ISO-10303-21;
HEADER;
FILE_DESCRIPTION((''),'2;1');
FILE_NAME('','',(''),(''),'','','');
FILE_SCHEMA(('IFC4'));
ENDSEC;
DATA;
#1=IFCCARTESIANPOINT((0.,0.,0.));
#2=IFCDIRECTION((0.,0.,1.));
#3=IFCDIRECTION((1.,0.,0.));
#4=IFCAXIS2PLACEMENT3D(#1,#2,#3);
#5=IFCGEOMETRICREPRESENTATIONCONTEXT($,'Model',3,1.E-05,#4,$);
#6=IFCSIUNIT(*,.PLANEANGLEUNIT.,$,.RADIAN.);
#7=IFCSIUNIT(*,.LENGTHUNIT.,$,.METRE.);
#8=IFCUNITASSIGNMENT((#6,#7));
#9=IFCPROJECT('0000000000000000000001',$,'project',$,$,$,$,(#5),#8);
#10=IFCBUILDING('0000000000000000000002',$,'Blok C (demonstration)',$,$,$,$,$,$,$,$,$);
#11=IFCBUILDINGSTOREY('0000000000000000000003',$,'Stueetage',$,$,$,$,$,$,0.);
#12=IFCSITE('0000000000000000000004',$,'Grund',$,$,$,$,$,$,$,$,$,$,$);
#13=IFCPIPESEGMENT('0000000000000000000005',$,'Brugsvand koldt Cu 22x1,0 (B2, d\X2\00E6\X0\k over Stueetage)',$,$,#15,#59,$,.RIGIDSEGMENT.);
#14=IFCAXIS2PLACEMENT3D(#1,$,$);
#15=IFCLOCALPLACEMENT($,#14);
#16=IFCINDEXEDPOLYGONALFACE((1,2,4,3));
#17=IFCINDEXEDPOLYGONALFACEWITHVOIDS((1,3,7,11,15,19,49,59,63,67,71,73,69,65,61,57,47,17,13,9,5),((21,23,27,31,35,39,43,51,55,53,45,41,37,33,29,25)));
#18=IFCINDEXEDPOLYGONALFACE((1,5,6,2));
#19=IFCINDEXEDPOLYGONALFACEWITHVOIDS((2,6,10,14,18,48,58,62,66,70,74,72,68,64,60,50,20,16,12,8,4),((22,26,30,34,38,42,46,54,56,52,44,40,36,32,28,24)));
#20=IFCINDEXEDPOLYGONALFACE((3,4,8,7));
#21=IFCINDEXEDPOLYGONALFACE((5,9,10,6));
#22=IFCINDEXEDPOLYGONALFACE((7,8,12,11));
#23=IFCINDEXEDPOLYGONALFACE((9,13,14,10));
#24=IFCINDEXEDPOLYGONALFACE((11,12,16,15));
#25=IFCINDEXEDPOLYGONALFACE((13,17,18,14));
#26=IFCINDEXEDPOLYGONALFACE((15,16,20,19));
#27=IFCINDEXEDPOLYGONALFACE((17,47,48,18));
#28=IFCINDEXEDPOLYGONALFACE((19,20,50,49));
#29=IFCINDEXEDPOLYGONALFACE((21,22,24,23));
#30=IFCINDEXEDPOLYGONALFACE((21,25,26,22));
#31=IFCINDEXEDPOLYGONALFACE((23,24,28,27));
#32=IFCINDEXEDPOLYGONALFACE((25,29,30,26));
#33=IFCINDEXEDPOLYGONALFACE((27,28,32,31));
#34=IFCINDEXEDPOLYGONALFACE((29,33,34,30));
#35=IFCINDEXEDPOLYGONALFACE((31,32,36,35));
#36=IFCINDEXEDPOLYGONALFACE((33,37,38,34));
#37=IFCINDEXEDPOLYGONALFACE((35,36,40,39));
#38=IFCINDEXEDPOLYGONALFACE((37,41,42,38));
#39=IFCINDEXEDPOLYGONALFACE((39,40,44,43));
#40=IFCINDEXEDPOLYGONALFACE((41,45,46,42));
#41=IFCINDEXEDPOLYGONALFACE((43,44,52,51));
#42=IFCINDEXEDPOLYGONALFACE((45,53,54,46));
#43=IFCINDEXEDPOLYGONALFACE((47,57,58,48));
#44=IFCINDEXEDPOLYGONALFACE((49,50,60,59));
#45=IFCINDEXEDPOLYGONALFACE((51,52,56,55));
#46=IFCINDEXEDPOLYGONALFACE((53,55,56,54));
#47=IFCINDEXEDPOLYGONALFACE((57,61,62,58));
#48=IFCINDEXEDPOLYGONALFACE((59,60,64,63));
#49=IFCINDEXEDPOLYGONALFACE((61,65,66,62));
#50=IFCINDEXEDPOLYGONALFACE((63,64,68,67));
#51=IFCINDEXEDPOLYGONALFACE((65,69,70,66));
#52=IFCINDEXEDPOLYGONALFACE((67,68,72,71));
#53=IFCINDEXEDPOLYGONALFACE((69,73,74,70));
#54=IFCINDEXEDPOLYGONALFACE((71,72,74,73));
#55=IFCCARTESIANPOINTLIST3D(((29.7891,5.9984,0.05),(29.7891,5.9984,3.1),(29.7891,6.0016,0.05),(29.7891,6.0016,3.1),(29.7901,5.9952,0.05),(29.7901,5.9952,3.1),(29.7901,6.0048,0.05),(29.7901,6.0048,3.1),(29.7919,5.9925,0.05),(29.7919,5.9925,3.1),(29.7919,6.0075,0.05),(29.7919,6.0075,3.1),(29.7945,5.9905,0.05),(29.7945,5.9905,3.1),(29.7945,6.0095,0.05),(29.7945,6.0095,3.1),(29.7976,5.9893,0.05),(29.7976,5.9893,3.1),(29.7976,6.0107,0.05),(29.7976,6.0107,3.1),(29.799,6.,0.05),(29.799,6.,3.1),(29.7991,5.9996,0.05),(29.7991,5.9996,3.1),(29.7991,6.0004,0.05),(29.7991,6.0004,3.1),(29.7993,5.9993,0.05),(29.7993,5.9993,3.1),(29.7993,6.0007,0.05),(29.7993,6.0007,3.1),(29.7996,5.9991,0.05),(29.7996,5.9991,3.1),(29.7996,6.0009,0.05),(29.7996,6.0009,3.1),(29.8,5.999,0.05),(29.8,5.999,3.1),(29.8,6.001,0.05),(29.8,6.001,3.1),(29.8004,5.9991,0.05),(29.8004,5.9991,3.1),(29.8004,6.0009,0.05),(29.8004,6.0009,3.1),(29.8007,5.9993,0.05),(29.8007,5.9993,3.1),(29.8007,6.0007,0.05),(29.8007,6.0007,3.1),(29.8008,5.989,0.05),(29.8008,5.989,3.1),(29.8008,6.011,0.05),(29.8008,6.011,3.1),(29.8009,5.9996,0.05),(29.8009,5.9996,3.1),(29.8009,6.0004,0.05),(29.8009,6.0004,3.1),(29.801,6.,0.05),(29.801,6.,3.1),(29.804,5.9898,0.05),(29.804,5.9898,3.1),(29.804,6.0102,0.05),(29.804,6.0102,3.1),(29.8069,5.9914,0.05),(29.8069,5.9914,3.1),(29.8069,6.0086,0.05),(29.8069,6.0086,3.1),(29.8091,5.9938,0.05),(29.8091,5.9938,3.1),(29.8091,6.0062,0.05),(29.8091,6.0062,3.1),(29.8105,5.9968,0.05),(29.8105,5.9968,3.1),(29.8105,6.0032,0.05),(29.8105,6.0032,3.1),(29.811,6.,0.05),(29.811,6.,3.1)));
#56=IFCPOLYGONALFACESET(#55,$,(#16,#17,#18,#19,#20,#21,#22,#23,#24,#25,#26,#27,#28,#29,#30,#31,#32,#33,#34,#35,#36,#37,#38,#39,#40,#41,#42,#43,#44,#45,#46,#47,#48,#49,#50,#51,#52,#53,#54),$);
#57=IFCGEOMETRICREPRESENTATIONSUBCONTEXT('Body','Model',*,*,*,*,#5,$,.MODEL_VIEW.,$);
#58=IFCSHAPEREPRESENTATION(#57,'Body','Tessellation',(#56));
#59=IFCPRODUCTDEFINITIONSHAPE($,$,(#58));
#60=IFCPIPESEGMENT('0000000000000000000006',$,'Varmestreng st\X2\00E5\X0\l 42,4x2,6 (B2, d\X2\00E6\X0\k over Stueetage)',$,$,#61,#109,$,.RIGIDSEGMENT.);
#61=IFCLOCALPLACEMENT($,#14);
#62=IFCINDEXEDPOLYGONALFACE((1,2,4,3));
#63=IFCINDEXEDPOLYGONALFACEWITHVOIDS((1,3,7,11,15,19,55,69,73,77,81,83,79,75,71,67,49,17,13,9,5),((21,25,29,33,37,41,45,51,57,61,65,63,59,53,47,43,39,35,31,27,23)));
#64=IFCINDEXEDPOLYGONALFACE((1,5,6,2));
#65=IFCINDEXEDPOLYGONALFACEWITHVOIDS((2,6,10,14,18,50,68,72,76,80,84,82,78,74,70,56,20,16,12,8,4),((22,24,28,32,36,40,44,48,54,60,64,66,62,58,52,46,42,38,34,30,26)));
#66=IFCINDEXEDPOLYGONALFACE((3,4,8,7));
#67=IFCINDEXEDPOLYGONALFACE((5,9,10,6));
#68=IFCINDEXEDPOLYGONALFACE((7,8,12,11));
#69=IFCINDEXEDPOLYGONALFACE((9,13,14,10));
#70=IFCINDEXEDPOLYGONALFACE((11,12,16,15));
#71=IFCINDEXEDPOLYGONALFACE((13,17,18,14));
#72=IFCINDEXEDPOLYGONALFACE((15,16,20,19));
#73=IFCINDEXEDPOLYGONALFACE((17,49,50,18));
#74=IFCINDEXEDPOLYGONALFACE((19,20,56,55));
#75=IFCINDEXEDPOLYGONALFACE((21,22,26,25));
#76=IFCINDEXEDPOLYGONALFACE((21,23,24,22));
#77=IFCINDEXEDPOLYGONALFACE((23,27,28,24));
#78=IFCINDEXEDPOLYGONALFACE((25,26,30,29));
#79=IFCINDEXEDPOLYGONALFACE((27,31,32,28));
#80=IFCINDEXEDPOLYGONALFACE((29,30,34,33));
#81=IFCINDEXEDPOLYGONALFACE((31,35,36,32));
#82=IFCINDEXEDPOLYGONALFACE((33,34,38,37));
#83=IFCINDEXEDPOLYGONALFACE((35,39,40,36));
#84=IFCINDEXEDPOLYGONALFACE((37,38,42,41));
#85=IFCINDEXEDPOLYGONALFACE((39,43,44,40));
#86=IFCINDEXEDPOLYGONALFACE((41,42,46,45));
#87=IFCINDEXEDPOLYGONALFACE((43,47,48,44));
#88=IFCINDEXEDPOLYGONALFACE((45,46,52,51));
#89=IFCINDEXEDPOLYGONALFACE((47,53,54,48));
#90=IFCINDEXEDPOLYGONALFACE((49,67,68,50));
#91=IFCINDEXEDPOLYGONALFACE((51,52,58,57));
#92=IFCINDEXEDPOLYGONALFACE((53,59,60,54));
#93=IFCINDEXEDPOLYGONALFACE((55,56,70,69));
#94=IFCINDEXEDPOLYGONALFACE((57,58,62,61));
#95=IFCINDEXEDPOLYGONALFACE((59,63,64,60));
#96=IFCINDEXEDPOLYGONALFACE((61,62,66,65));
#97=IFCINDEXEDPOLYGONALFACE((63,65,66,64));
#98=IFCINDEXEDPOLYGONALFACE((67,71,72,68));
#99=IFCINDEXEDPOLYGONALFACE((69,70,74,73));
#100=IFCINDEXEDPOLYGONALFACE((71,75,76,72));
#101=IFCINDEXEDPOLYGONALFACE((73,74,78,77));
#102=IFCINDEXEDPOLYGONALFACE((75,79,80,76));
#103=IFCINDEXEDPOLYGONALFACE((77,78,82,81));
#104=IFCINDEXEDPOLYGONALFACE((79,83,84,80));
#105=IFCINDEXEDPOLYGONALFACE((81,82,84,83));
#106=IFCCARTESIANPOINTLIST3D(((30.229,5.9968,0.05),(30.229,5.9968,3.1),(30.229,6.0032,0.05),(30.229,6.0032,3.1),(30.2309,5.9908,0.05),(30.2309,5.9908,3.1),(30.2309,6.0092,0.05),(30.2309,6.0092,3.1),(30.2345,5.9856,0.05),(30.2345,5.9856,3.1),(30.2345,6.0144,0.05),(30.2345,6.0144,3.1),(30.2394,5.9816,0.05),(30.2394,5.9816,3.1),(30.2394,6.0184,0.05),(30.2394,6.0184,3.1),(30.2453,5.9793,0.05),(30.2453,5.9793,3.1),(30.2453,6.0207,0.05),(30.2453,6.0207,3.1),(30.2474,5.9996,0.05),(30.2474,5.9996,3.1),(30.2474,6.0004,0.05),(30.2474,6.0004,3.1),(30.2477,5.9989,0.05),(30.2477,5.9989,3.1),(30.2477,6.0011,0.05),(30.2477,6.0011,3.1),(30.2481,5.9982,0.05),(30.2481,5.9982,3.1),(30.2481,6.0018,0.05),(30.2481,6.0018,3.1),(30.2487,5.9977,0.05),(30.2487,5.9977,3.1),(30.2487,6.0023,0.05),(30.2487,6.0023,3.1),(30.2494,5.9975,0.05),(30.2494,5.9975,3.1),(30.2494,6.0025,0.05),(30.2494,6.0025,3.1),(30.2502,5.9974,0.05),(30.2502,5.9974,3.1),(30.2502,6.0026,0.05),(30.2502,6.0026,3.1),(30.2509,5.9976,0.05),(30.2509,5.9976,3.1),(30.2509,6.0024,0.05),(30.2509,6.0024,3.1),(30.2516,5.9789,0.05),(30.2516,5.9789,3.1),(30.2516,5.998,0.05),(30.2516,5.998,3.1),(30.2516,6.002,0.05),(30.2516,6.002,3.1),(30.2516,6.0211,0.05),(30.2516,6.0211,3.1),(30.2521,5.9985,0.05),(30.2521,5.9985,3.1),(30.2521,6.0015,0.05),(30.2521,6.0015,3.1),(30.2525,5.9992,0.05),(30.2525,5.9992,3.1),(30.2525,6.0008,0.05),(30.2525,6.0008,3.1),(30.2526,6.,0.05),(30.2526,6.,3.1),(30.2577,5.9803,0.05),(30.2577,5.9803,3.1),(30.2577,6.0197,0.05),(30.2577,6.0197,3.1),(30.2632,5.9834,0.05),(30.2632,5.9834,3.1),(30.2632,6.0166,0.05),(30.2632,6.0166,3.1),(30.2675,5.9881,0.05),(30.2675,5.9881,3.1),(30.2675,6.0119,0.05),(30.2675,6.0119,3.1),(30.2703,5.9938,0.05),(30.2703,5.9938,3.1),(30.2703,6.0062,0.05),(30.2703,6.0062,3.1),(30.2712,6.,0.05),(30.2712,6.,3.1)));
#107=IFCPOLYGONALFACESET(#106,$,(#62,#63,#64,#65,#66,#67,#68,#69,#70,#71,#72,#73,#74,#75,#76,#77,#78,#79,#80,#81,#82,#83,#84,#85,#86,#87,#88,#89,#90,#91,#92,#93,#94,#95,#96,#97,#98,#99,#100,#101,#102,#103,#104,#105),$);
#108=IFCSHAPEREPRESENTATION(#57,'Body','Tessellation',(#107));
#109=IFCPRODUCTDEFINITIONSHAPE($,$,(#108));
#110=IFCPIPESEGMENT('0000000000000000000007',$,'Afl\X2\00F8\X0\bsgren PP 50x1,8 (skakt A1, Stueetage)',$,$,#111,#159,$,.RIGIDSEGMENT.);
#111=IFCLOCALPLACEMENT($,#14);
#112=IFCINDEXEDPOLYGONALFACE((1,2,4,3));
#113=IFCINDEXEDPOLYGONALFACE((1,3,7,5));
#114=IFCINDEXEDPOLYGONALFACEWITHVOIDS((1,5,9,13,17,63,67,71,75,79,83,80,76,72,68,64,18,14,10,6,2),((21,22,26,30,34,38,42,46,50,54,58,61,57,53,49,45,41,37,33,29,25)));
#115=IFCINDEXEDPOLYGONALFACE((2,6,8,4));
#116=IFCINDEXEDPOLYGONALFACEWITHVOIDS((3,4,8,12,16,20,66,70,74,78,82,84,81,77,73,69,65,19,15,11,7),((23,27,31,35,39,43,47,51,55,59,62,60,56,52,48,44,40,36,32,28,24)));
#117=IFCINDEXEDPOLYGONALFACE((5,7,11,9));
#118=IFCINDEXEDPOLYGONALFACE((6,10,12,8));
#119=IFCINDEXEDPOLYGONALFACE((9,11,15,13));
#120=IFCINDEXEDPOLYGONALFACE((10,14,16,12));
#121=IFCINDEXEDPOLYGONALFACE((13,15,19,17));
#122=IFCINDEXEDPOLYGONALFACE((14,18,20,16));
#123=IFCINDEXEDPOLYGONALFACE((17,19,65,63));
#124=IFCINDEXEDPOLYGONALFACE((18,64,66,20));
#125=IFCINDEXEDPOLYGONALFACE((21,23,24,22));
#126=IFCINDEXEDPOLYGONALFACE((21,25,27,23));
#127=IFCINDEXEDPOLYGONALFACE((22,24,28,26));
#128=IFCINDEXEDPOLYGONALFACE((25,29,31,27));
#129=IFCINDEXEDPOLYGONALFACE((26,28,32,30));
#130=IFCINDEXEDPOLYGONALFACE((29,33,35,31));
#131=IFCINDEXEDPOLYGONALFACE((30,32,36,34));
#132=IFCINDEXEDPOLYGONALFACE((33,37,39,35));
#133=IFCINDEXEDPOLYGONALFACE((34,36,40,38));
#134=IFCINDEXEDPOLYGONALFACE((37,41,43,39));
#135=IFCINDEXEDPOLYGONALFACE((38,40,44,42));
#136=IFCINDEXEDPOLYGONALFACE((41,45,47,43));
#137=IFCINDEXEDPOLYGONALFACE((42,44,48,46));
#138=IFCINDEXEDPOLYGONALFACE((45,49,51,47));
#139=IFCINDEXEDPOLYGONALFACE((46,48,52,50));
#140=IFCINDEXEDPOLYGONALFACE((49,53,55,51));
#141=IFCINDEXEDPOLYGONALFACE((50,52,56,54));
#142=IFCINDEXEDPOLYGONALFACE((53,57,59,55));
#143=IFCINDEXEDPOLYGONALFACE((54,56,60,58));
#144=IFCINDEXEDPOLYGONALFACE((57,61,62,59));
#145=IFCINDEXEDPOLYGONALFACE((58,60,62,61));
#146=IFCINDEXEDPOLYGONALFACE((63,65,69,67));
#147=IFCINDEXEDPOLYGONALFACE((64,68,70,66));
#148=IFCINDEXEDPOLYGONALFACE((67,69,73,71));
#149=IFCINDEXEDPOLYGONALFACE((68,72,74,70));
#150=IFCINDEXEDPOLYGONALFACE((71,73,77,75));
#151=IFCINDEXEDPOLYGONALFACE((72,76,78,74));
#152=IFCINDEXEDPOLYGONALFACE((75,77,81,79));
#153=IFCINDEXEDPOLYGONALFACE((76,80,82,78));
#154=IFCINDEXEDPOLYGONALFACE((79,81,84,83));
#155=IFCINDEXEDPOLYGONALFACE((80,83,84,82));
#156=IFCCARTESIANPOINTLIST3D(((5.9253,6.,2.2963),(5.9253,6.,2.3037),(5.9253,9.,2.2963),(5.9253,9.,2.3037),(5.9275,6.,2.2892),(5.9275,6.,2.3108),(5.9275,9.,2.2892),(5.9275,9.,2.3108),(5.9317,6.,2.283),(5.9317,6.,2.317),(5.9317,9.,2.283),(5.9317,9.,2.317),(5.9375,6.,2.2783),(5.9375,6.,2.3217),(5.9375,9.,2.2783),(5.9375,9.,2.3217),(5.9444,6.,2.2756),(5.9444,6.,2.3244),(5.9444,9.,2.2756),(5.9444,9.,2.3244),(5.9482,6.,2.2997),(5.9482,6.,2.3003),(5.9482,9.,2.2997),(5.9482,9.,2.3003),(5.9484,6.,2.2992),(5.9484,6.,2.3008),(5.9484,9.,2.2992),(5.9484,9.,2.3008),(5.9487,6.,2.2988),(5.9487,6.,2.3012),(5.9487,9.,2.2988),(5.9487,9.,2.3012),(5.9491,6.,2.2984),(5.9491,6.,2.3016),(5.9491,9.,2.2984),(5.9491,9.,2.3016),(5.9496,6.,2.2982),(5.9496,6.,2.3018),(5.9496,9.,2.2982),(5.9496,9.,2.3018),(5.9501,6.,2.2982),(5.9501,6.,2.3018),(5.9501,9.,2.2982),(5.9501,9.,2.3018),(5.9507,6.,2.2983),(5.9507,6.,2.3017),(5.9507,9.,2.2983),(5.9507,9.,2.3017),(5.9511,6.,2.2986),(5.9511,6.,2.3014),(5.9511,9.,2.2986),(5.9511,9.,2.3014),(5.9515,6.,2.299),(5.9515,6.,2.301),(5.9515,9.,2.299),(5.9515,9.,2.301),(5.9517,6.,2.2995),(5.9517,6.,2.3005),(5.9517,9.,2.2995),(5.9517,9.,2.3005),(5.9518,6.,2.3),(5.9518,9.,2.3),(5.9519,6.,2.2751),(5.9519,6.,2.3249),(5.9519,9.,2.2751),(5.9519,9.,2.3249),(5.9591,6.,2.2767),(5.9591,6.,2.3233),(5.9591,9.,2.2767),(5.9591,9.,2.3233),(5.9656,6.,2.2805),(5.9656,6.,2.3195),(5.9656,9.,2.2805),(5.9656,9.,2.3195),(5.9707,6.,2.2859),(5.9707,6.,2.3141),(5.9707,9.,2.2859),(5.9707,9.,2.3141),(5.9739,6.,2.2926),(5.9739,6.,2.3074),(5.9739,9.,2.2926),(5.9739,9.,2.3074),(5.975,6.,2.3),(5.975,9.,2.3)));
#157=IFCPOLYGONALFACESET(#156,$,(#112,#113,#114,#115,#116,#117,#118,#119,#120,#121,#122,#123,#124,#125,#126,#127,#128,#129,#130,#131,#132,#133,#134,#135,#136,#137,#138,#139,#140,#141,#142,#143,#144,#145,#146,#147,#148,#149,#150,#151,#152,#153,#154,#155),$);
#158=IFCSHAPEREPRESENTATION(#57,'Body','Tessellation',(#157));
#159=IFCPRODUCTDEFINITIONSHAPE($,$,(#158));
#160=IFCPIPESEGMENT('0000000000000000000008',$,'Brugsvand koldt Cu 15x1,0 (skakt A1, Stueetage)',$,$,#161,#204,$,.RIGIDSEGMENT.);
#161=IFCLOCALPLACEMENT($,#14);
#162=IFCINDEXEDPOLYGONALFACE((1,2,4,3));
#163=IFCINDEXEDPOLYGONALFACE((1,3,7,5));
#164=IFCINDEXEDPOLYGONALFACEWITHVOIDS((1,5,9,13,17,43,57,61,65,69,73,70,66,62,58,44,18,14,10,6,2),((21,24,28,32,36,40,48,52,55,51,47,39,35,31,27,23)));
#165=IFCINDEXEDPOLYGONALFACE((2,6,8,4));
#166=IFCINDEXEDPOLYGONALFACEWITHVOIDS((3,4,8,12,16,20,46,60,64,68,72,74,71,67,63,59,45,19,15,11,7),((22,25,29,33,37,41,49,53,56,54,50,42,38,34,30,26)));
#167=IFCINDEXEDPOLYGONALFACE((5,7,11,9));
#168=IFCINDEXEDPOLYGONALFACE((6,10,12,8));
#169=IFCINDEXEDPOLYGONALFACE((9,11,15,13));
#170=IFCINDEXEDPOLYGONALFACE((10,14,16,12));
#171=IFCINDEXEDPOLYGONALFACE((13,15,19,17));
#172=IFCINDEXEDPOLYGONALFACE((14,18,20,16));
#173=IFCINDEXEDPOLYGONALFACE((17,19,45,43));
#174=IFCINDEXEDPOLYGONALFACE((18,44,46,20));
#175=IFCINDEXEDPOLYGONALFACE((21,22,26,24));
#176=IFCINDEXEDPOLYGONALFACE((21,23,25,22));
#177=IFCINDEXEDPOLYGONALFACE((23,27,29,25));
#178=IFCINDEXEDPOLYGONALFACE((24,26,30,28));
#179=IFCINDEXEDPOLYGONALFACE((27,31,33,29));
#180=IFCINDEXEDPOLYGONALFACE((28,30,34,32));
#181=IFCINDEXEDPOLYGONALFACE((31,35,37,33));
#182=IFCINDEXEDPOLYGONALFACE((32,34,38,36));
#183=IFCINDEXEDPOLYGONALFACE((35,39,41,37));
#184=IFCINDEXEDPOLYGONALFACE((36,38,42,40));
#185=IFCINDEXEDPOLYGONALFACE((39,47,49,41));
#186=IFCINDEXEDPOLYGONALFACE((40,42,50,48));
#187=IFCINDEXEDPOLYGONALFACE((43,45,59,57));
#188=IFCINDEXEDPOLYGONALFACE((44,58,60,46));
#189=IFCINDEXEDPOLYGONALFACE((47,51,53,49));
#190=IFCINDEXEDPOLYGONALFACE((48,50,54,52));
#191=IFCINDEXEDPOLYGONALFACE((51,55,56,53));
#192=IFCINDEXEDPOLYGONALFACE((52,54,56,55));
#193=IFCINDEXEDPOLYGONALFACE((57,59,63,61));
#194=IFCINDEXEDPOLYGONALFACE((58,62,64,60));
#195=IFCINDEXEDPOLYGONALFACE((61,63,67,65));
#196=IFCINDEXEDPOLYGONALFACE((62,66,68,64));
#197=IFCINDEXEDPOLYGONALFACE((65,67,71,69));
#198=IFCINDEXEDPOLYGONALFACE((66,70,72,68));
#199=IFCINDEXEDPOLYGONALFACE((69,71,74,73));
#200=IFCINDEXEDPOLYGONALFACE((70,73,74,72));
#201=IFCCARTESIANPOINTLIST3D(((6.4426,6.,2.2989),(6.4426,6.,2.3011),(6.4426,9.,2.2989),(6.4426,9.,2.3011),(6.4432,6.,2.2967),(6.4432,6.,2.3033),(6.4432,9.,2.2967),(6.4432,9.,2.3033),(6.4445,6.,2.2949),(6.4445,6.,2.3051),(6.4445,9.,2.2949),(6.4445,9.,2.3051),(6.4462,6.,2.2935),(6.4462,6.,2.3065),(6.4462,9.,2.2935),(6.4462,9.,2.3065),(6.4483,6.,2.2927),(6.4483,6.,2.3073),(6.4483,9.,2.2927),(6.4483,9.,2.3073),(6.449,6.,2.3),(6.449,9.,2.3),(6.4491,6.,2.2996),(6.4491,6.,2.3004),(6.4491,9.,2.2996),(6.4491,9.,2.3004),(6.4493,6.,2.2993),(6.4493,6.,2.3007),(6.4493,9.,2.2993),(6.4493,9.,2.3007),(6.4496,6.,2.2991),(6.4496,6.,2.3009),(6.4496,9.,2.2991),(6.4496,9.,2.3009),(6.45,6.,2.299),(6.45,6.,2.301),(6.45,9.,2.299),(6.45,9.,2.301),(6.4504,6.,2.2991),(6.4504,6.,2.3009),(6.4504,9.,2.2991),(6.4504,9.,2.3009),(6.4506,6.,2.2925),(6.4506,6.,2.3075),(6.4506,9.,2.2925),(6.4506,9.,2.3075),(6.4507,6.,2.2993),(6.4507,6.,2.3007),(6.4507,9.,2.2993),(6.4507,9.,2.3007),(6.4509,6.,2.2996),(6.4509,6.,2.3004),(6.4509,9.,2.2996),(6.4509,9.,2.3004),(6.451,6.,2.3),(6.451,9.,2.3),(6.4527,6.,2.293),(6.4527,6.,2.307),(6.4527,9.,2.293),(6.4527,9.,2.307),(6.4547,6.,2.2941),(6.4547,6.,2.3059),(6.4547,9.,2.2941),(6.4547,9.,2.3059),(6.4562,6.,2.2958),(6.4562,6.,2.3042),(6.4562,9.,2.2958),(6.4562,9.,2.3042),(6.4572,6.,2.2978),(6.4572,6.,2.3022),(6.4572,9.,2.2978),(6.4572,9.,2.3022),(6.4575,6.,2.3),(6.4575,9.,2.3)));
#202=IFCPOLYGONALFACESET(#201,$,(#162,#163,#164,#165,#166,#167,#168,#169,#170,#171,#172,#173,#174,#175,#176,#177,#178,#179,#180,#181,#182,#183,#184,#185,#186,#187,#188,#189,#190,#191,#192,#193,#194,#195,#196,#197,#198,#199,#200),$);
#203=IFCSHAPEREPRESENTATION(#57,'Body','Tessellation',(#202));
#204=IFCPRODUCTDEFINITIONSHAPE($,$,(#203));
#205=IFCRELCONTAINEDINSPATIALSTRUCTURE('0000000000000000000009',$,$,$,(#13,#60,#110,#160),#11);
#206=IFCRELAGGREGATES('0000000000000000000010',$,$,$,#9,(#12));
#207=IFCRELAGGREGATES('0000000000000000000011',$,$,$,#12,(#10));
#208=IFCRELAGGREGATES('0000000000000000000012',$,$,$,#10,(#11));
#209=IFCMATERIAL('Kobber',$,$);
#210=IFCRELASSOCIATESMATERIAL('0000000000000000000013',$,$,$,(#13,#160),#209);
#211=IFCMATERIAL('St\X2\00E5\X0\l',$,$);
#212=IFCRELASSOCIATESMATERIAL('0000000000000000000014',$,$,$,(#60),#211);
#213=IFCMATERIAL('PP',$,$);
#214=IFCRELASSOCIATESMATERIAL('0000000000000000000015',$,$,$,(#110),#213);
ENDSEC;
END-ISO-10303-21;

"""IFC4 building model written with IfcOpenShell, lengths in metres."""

from ifc_helpers import new_model, si_unit, frame, origin_with_axes, place, context, subcontext, project, spatial, hollow_circle, extrude, material, element, save


model = new_model("IFC4")

# Units and contexts
model_context = context("Model", 3, precision=1e-05, world=origin_with_axes())
body_context = subcontext(model_context, "Body", "Model", "MODEL_VIEW")
ifc_project = project(units=[si_unit("PLANEANGLEUNIT", "RADIAN"), si_unit("LENGTHUNIT", "METRE")], contexts=[model_context])

# Site, building, storey
site = spatial("IfcSite", under=ifc_project, Name="Grund")
building = spatial("IfcBuilding", under=site, Name="Blok C (demonstration)")
storey = spatial("IfcBuildingStorey", under=building, Name="Stueetage", Elevation=0.0)

# Pipe segments
ifc_material_1 = material(Name="Kobber")
ifc_material_2 = material(Name="PP")
pipe_segment_1_placement = place(None, origin_with_axes())
element("IfcPipeSegment", 1, at=pipe_segment_1_placement, inside=storey, material=ifc_material_1, Name="Brugsvand koldt Cu 22x1,0 (B2, dæk over Stueetage)", PredefinedType="RIGIDSEGMENT", context=body_context, shape_type="SweptSolid", body=[
    extrude(hollow_circle(Radius=0.011, WallThickness=0.01), frame((29.8, 6.0, 0.05), z_axis=(0.0, 0.0, 1.0), x_axis=(1.0, 0.0, 0.0)), (0.0, 0.0, 1.0), 3.05),
])
ifc_material_3 = material(Name="Stål")
pipe_segment_2_placement = place(None, origin_with_axes())
element("IfcPipeSegment", 2, at=pipe_segment_2_placement, inside=storey, material=ifc_material_3, Name="Varmestreng stål 42,4x2,6 (B2, dæk over Stueetage)", PredefinedType="RIGIDSEGMENT", context=body_context, shape_type="SweptSolid", body=[
    extrude(hollow_circle(Radius=0.0212, WallThickness=0.0186), frame((30.25, 6.0, 0.05), z_axis=(0.0, 0.0, 1.0), x_axis=(1.0, 0.0, 0.0)), (0.0, 0.0, 1.0), 3.05),
])
pipe_segment_3_placement = place(None, origin_with_axes())
element("IfcPipeSegment", 3, at=pipe_segment_3_placement, inside=storey, material=ifc_material_2, Name="Afløbsgren PP 50x1,8 (skakt A1, Stueetage)", PredefinedType="RIGIDSEGMENT", context=body_context, shape_type="SweptSolid", body=[
    extrude(hollow_circle(Radius=0.025, WallThickness=0.0232), frame((5.95, 6.0, 2.3), z_axis=(0.0, 1.0, 0.0), x_axis=(1.0, 0.0, 0.0)), (0.0, 0.0, 1.0), 3.0),
])
pipe_segment_4_placement = place(None, origin_with_axes())
element("IfcPipeSegment", 4, at=pipe_segment_4_placement, inside=storey, material=ifc_material_1, Name="Brugsvand koldt Cu 15x1,0 (skakt A1, Stueetage)", PredefinedType="RIGIDSEGMENT", context=body_context, shape_type="SweptSolid", body=[
    extrude(hollow_circle(Radius=0.0075, WallThickness=0.0065), frame((6.45, 6.0, 2.3), z_axis=(0.0, 1.0, 0.0), x_axis=(1.0, 0.0, 0.0)), (0.0, 0.0, 1.0), 3.0),
])

save(model, "model.ifc")
